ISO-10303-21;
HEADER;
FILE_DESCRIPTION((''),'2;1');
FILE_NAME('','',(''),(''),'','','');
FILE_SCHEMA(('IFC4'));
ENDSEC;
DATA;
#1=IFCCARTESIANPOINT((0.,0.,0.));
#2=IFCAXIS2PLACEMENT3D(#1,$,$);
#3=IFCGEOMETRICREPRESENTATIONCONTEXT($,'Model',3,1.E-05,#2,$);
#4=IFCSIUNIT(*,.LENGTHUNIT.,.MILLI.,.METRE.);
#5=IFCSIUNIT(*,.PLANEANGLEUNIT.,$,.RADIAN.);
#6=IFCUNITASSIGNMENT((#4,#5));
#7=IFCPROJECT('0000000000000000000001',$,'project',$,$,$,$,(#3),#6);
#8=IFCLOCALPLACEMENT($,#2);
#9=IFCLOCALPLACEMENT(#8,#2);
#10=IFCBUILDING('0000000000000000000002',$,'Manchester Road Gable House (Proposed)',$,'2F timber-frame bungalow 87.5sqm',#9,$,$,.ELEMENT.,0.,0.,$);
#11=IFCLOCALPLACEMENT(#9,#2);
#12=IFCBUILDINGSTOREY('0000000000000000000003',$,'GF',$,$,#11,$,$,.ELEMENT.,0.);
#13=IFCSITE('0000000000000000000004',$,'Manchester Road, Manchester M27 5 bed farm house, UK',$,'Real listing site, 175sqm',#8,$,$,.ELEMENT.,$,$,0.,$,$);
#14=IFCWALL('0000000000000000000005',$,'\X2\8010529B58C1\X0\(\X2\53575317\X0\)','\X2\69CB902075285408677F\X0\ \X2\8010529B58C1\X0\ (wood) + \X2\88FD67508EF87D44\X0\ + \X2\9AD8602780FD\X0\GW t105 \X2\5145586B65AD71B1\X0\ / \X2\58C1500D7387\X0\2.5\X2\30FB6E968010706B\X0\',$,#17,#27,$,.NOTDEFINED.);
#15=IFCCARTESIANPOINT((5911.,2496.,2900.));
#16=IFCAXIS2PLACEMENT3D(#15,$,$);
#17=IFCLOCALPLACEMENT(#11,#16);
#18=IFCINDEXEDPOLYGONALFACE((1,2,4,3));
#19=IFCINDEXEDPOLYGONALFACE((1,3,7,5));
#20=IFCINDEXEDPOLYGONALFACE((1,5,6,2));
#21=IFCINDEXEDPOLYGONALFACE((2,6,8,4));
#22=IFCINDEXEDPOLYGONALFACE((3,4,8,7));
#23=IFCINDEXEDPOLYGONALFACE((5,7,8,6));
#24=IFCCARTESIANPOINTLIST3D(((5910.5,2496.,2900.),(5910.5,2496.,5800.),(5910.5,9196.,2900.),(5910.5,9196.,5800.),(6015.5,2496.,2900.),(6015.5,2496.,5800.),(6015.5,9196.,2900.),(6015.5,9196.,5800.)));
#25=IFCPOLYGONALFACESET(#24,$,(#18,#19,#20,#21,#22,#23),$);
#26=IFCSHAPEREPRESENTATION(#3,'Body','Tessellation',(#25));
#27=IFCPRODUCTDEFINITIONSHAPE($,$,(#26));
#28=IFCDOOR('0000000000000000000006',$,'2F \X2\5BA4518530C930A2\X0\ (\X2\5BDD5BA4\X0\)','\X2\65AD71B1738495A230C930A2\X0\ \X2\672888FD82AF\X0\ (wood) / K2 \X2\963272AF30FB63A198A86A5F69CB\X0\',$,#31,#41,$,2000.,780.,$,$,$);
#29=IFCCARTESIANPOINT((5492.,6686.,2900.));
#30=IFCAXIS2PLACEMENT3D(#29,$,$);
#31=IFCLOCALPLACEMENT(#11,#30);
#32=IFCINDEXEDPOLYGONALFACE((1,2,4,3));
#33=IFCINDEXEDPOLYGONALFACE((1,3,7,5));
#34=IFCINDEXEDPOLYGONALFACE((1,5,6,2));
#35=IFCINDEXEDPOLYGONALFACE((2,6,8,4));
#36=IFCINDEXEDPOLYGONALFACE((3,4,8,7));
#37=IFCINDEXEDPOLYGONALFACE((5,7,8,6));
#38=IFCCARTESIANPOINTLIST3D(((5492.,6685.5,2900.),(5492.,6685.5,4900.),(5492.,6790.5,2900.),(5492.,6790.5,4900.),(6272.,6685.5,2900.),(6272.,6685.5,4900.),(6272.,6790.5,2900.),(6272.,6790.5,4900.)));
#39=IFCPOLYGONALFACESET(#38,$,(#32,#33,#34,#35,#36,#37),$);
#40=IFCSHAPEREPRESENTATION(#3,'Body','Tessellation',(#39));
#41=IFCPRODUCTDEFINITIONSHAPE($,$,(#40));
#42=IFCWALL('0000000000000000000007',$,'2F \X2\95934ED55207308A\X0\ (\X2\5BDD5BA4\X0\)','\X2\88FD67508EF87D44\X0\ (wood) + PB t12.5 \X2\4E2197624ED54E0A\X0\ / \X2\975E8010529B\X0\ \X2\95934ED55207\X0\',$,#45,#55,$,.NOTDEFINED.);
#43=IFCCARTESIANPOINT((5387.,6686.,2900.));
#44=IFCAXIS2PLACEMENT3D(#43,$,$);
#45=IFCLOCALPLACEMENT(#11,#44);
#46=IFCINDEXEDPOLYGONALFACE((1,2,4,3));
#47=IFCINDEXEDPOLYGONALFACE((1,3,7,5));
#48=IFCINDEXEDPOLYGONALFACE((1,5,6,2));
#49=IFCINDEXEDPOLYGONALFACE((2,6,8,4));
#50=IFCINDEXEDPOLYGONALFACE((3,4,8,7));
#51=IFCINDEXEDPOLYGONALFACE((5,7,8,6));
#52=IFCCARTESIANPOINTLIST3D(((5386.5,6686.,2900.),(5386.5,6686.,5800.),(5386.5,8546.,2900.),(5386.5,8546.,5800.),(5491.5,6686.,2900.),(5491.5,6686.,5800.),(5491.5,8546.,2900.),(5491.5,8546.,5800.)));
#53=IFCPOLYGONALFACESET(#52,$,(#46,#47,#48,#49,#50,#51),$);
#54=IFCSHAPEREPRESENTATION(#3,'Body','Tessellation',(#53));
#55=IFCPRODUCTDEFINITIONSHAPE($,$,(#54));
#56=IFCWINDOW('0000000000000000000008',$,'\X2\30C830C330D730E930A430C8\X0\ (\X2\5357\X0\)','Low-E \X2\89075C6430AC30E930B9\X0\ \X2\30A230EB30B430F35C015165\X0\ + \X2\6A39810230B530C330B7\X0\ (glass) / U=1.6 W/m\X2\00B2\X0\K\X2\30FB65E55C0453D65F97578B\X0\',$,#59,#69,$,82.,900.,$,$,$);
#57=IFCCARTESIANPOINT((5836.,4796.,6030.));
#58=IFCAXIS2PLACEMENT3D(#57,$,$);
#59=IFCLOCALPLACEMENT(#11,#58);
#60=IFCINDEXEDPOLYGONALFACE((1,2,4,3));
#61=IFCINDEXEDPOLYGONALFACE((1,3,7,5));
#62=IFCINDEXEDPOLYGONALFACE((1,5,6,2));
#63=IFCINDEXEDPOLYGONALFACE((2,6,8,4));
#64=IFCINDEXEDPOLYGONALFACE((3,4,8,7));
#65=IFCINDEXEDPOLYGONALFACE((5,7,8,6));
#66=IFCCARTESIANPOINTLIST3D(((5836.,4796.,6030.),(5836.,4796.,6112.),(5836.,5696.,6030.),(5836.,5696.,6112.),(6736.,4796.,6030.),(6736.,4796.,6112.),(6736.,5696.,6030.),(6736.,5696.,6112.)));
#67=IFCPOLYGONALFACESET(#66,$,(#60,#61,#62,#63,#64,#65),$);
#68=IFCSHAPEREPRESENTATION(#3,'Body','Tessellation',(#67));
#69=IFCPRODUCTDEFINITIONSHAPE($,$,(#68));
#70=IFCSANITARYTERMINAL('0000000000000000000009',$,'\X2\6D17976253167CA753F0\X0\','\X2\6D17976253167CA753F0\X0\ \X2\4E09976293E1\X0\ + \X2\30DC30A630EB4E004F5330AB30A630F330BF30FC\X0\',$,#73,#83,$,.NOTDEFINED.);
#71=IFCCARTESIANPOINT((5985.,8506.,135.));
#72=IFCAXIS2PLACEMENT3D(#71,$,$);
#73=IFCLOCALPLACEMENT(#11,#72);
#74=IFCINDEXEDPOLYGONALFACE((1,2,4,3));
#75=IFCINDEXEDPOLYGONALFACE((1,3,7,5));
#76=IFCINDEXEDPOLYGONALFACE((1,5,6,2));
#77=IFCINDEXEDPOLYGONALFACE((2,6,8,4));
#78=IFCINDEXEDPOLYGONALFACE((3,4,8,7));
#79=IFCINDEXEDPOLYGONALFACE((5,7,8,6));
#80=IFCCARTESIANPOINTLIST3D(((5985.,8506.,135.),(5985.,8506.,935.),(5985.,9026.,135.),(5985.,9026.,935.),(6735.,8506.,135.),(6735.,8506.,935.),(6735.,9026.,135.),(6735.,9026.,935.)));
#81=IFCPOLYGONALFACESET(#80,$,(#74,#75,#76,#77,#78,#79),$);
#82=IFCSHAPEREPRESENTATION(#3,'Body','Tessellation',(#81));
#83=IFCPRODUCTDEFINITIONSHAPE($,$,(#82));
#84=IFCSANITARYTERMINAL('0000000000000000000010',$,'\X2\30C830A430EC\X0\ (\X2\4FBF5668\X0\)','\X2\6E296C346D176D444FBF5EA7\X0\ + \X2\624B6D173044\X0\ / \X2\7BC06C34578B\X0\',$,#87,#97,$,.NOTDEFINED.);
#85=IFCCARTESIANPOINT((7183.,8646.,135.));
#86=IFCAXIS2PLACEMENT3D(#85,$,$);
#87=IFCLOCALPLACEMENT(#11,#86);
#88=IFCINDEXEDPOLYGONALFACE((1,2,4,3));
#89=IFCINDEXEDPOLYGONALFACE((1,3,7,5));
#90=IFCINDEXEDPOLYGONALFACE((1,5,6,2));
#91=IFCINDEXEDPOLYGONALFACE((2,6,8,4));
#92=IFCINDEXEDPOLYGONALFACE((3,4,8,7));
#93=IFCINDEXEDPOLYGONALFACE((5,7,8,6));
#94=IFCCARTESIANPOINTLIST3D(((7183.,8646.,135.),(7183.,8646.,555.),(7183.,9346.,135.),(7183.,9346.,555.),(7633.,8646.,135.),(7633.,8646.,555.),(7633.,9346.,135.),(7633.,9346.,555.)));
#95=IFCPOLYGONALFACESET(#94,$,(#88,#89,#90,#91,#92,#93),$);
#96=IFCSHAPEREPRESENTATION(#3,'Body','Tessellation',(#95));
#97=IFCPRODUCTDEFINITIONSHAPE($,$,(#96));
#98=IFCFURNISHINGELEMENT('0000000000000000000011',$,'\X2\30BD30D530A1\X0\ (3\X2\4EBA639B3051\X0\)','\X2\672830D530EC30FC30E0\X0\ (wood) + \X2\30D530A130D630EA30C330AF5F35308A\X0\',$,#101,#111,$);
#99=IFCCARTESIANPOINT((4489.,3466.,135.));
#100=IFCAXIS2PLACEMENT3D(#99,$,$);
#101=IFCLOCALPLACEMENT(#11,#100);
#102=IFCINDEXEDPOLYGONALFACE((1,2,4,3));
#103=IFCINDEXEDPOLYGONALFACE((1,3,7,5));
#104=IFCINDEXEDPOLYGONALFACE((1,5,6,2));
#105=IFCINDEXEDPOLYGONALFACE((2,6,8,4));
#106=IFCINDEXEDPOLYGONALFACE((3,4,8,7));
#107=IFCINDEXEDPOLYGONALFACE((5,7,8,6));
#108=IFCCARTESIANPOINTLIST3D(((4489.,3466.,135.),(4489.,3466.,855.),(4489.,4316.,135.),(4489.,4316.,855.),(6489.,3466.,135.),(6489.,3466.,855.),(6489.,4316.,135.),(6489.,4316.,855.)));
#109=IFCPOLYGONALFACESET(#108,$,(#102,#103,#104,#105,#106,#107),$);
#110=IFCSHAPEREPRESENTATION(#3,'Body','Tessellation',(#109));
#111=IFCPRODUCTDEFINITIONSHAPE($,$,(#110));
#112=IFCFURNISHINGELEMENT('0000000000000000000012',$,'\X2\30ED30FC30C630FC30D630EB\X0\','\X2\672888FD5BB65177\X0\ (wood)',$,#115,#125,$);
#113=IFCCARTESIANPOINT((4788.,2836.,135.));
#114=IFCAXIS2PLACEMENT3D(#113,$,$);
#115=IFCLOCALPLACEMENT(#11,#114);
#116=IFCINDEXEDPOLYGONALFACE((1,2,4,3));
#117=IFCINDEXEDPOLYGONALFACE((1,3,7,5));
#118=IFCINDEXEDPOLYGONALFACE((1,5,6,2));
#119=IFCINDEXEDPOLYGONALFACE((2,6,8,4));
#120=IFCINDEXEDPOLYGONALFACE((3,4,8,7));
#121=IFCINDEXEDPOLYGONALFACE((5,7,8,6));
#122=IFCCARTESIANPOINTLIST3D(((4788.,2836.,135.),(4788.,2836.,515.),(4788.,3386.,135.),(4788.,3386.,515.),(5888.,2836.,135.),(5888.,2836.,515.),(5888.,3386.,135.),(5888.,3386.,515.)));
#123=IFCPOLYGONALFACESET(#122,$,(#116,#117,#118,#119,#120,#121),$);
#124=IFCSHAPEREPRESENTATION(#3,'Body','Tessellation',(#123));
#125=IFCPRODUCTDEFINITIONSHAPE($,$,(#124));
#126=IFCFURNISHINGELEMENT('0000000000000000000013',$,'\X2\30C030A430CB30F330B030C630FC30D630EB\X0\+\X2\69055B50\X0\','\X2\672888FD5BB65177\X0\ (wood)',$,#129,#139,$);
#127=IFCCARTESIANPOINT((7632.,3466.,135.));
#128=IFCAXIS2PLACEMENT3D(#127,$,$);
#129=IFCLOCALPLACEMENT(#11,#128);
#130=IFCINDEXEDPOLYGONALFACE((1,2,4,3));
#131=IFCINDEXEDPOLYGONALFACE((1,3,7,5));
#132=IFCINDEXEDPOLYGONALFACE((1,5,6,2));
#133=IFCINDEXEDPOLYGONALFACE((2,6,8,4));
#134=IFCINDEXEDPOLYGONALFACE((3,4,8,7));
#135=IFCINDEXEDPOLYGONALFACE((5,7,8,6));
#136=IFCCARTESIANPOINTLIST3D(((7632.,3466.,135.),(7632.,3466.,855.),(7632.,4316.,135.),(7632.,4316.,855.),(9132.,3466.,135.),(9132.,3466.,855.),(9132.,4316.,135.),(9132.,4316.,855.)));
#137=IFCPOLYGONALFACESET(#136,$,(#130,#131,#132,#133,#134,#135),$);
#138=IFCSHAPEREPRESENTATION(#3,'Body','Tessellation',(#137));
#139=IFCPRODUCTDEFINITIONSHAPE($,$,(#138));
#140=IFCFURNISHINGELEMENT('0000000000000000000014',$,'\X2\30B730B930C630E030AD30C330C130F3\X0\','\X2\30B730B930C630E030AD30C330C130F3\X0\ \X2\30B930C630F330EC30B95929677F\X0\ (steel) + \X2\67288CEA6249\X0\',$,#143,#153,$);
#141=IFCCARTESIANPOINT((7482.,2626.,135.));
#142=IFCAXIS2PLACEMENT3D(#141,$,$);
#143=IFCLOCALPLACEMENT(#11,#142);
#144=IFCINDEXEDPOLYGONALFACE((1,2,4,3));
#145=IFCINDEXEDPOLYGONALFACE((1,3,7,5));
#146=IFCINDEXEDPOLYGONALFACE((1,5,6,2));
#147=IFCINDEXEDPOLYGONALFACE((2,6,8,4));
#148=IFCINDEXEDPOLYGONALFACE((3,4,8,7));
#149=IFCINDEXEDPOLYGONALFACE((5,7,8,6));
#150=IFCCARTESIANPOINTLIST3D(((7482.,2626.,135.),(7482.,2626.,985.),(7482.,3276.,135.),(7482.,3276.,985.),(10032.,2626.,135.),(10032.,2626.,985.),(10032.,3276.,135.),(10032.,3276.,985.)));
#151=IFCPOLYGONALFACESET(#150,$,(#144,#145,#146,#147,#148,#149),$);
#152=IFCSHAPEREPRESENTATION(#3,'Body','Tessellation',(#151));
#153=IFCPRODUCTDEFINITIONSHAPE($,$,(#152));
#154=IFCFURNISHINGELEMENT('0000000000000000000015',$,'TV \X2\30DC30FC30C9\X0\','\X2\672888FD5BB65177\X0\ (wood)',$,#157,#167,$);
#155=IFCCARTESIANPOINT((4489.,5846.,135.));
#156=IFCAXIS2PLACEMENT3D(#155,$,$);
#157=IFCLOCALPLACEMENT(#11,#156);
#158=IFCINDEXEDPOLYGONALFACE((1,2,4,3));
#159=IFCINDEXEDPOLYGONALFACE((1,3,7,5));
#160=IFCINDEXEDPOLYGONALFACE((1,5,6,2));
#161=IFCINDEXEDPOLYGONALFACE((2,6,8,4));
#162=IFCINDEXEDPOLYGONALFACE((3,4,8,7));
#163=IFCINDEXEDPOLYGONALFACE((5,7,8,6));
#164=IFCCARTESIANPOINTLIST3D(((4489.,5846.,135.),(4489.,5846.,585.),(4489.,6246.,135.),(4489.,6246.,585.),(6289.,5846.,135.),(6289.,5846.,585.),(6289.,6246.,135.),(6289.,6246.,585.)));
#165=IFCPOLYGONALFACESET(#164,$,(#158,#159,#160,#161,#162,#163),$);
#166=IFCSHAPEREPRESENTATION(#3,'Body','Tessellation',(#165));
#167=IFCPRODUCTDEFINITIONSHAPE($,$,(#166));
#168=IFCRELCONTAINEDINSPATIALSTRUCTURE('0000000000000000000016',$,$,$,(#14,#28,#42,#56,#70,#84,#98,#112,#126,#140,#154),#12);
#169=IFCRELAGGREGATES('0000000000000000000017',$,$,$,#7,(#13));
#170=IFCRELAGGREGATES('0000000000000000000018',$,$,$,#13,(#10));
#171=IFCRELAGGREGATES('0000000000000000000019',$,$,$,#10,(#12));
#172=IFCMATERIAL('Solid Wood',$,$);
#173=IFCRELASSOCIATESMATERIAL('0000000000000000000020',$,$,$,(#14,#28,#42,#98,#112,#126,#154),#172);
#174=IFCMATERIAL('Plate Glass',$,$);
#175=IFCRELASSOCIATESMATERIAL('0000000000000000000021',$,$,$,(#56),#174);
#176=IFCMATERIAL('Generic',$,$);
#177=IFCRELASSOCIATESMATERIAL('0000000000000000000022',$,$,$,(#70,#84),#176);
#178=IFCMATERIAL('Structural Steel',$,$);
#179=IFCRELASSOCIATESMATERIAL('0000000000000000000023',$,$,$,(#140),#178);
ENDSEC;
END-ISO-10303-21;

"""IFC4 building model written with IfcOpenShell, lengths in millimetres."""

from ifc_helpers import new_model, si_unit, frame, frame_2d, origin, place, context, project, spatial, rectangle, extrude, material, element, fill, save


model = new_model("IFC4")

# Units and contexts
model_context = context("Model", 3, precision=1e-05, world=origin())
ifc_project = project(units=[si_unit("LENGTHUNIT", "METRE", prefix="MILLI"), si_unit("PLANEANGLEUNIT", "RADIAN")], contexts=[model_context])

# Site, building, storey
site_placement = place(None, origin())
site = spatial("IfcSite", under=ifc_project, at=site_placement, Name="Manchester Road, Manchester M27 5 bed farm house, UK", ObjectType="Real listing site, 175sqm", CompositionType="ELEMENT", RefElevation=0.0)
building_placement = place(site_placement, origin())
building = spatial("IfcBuilding", under=site, at=building_placement, Name="Manchester Road Gable House (Proposed)", ObjectType="2F timber-frame bungalow 87.5sqm", CompositionType="ELEMENT", ElevationOfRefHeight=0.0, ElevationOfTerrain=0.0)
storey_placement = place(building_placement, origin())
storey = spatial("IfcBuildingStorey", under=building, at=storey_placement, Name="GF", CompositionType="ELEMENT", Elevation=0.0)

# Shared definitions
ifc_material_1 = material(Name="Solid Wood")

# Wall, opening, door
wall_1_placement = place(storey_placement, frame((5911.0, 2496.0, 2900.0)))
wall_1 = element("IfcWall", 1, at=wall_1_placement, inside=storey, material=ifc_material_1, Name="耐力壁(南北)", Description="構造用合板 耐力壁 (wood) + 製材軸組 + 高性能GW t105 充填断熱 / 壁倍率2.5・準耐火", PredefinedType="NOTDEFINED", context=model_context, shape_type="SweptSolid", body=[
    extrude(rectangle(XDim=105.0, YDim=6700.0, at=frame_2d((52.0, 3350.0))), frame((5911.0, 2496.0, 2900.0)), (0.0, 0.0, 1.0), 2900.0),
])
opening_1_placement = place(storey_placement, frame((5492.0, 6686.0, 2900.0)))
opening_1 = element("IfcOpeningElement", 2, at=opening_1_placement, cuts=wall_1, PredefinedType="NOTDEFINED", context=model_context, shape_type="SweptSolid", body=[
    extrude(rectangle(XDim=780.0, YDim=105.0, at=frame_2d((390.0, 52.0))), frame((5492.0, 6686.0, 2900.0)), (0.0, 0.0, 1.0), 2000.0),
])
door_1_placement = place(storey_placement, frame((5492.0, 6686.0, 2900.0)))
door_1 = element("IfcDoor", 3, at=door_1_placement, inside=storey, material=ifc_material_1, Name="2F 室内ドア (寝室)", Description="断熱玄関ドア 木製芯 (wood) / K2 防犯・採風機構", OverallHeight=2000.0, OverallWidth=780.0, context=model_context, shape_type="SweptSolid", body=[
    extrude(rectangle(XDim=780.0, YDim=105.0, at=frame_2d((390.0, 52.0))), frame((5492.0, 6686.0, 2900.0)), (0.0, 0.0, 1.0), 2000.0),
])
fill(opening_1, door_1)

# Wall
wall_2_placement = place(storey_placement, frame((5387.0, 6686.0, 2900.0)))
element("IfcWall", 4, at=wall_2_placement, inside=storey, material=ifc_material_1, Name="2F 間仕切り (寝室)", Description="製材軸組 (wood) + PB t12.5 両面仕上 / 非耐力 間仕切", PredefinedType="NOTDEFINED", context=model_context, shape_type="SweptSolid", body=[
    extrude(rectangle(XDim=105.0, YDim=1860.0, at=frame_2d((52.0, 930.0))), frame((5387.0, 6686.0, 2900.0)), (0.0, 0.0, 1.0), 2900.0),
])

# Window
ifc_material_2 = material(Name="Plate Glass")
window_placement = place(storey_placement, frame((5836.0, 4796.0, 6030.0)))
element("IfcWindow", 5, at=window_placement, inside=storey, material=ifc_material_2, Name="トップライト (南)", Description="Low-E 複層ガラス アルゴン封入 + 樹脂サッシ (glass) / U=1.6 W/m²K・日射取得型", OverallHeight=82.0, OverallWidth=900.0, context=model_context, shape_type="SweptSolid", body=[
    extrude(rectangle(XDim=900.0, YDim=900.0, at=frame_2d((450.0, 450.0))), frame((5836.0, 4796.0, 6030.0)), (0.0, 0.0, 1.0), 82.0),
])

# Sanitary terminals
ifc_material_3 = material(Name="Generic")
sanitary_terminal_1_placement = place(storey_placement, frame((5985.0, 8506.0, 135.0)))
element("IfcSanitaryTerminal", 6, at=sanitary_terminal_1_placement, inside=storey, material=ifc_material_3, Name="洗面化粧台", Description="洗面化粧台 三面鏡 + ボウル一体カウンター", PredefinedType="NOTDEFINED", context=model_context, shape_type="SweptSolid", body=[
    extrude(rectangle(XDim=750.0, YDim=520.0, at=frame_2d((375.0, 260.0))), frame((5985.0, 8506.0, 135.0)), (0.0, 0.0, 1.0), 800.0),
])
sanitary_terminal_2_placement = place(storey_placement, frame((7183.0, 8646.0, 135.0)))
element("IfcSanitaryTerminal", 7, at=sanitary_terminal_2_placement, inside=storey, material=ifc_material_3, Name="トイレ (便器)", Description="温水洗浄便座 + 手洗い / 節水型", PredefinedType="NOTDEFINED", context=model_context, shape_type="SweptSolid", body=[
    extrude(rectangle(XDim=450.0, YDim=700.0, at=frame_2d((225.0, 350.0))), frame((7183.0, 8646.0, 135.0)), (0.0, 0.0, 1.0), 420.0),
])

# Furnishing elements
furnishing_1_placement = place(storey_placement, frame((4489.0, 3466.0, 135.0)))
element("IfcFurnishingElement", 8, at=furnishing_1_placement, inside=storey, material=ifc_material_1, Name="ソファ (3人掛け)", Description="木フレーム (wood) + ファブリック張り", context=model_context, shape_type="SweptSolid", body=[
    extrude(rectangle(XDim=2000.0, YDim=850.0, at=frame_2d((1000.0, 425.0))), frame((4489.0, 3466.0, 135.0)), (0.0, 0.0, 1.0), 720.0),
])
furnishing_2_placement = place(storey_placement, frame((4788.0, 2836.0, 135.0)))
element("IfcFurnishingElement", 9, at=furnishing_2_placement, inside=storey, material=ifc_material_1, Name="ローテーブル", Description="木製家具 (wood)", context=model_context, shape_type="SweptSolid", body=[
    extrude(rectangle(XDim=1100.0, YDim=550.0, at=frame_2d((550.0, 275.0))), frame((4788.0, 2836.0, 135.0)), (0.0, 0.0, 1.0), 380.0),
])
furnishing_3_placement = place(storey_placement, frame((7632.0, 3466.0, 135.0)))
element("IfcFurnishingElement", 10, at=furnishing_3_placement, inside=storey, material=ifc_material_1, Name="ダイニングテーブル+椅子", Description="木製家具 (wood)", context=model_context, shape_type="SweptSolid", body=[
    extrude(rectangle(XDim=1500.0, YDim=850.0, at=frame_2d((750.0, 425.0))), frame((7632.0, 3466.0, 135.0)), (0.0, 0.0, 1.0), 720.0),
])
ifc_material_4 = material(Name="Structural Steel")
furnishing_4_placement = place(storey_placement, frame((7482.0, 2626.0, 135.0)))
element("IfcFurnishingElement", 11, at=furnishing_4_placement, inside=storey, material=ifc_material_4, Name="システムキッチン", Description="システムキッチン ステンレス天板 (steel) + 木質扉", context=model_context, shape_type="SweptSolid", body=[
    extrude(rectangle(XDim=2550.0, YDim=650.0, at=frame_2d((1275.0, 325.0))), frame((7482.0, 2626.0, 135.0)), (0.0, 0.0, 1.0), 850.0),
])
furnishing_5_placement = place(storey_placement, frame((4489.0, 5846.0, 135.0)))
element("IfcFurnishingElement", 12, at=furnishing_5_placement, inside=storey, material=ifc_material_1, Name="TV ボード", Description="木製家具 (wood)", context=model_context, shape_type="SweptSolid", body=[
    extrude(rectangle(XDim=1800.0, YDim=400.0, at=frame_2d((900.0, 200.0))), frame((4489.0, 5846.0, 135.0)), (0.0, 0.0, 1.0), 450.0),
])

save(model, "model.ifc")
